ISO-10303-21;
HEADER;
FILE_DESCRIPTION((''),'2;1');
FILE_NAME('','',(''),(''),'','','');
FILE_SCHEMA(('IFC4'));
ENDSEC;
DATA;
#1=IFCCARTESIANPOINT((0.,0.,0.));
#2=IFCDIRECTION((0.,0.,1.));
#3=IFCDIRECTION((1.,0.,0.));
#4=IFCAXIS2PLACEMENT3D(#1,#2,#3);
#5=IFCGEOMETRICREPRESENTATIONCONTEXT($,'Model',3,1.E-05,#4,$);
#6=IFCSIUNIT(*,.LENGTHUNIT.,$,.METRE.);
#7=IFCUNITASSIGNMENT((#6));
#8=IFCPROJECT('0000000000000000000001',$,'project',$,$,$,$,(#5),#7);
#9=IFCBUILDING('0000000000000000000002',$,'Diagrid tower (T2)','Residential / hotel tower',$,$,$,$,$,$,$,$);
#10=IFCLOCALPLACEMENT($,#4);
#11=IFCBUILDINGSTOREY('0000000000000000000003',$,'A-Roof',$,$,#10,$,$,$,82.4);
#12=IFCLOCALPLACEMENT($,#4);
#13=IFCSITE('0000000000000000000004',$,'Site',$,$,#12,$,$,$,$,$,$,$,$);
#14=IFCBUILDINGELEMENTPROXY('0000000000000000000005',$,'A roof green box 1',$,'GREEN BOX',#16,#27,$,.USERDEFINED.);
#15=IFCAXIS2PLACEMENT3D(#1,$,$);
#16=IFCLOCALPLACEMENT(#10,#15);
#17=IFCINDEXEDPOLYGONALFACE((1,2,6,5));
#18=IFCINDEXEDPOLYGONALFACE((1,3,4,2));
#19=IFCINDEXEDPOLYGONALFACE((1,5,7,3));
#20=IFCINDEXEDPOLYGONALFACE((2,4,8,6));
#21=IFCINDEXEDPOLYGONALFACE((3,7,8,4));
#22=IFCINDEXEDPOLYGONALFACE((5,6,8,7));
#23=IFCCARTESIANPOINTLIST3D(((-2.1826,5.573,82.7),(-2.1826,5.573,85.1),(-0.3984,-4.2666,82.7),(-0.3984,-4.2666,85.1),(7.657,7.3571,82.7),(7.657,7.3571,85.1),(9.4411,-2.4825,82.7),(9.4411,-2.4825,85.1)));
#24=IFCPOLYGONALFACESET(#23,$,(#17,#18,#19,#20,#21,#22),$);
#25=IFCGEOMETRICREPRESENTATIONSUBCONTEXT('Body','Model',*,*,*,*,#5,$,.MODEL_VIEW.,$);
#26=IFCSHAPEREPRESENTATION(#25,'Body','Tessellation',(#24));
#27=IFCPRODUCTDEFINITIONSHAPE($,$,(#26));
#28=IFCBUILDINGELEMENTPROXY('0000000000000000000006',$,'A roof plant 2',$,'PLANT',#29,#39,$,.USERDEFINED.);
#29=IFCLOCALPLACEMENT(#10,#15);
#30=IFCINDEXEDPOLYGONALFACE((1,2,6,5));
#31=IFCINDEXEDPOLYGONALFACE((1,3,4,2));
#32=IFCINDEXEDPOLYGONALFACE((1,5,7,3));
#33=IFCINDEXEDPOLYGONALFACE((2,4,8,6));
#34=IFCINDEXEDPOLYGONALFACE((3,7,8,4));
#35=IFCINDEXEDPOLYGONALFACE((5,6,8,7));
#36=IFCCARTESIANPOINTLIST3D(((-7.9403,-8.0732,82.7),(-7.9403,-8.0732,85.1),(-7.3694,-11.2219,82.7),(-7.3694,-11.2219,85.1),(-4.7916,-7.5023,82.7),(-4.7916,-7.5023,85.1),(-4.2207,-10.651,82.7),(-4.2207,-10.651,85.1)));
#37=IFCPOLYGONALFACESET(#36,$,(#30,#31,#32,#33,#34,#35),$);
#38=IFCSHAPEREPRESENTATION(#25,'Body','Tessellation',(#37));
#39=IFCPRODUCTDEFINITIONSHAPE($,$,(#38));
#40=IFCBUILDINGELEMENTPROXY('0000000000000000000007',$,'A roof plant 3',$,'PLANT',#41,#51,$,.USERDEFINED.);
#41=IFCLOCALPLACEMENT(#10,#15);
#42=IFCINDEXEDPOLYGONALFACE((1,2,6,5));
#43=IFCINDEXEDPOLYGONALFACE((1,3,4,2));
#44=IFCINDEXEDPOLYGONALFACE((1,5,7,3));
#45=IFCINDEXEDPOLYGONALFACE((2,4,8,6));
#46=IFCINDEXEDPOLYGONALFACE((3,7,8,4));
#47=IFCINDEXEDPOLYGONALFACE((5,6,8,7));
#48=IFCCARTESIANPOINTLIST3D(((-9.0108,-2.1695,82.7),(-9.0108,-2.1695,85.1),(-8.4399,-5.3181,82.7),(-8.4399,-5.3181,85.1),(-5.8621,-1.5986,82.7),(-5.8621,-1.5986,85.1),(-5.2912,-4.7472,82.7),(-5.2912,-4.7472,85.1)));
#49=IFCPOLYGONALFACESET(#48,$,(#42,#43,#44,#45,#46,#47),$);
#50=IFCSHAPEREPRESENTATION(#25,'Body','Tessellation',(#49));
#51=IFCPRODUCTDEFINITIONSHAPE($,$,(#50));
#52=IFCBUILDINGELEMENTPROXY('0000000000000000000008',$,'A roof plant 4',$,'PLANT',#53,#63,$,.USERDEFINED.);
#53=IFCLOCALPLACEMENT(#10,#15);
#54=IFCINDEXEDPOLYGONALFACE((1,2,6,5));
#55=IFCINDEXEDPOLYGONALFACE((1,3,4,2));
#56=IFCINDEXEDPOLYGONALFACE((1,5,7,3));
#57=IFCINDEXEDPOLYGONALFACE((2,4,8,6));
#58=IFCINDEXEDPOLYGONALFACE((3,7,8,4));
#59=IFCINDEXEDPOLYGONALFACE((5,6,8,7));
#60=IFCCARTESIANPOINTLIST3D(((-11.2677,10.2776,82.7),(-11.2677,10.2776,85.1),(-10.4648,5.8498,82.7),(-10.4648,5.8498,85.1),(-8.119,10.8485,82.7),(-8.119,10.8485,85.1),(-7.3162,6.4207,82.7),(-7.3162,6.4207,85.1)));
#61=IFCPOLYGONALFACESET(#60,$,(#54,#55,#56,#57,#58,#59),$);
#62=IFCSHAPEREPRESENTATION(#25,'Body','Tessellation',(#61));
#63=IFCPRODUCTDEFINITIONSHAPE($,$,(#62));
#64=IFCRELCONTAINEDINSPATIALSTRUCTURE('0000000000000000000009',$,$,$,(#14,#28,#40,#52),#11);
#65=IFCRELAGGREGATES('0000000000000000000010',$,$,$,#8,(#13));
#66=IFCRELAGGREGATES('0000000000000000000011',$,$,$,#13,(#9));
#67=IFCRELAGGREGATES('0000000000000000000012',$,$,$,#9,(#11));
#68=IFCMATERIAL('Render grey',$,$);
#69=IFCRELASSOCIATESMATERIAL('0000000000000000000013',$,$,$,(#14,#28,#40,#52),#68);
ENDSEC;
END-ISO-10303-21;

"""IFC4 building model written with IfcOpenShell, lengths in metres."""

from ifc_helpers import new_model, si_unit, frame, origin_with_axes, place, context, subcontext, project, spatial, polyline, outline, extrude, material, element, save


model = new_model("IFC4")

# Units and contexts
model_context = context("Model", 3, precision=1e-05, world=origin_with_axes())
body_context = subcontext(model_context, "Body", "Model", "MODEL_VIEW")
ifc_project = project(units=[si_unit("LENGTHUNIT", "METRE")], contexts=[model_context])

# Site, building, storey
site_placement = place(None, origin_with_axes())
site = spatial("IfcSite", under=ifc_project, at=site_placement, Name="Site")
building = spatial("IfcBuilding", under=site, Name="Diagrid tower (T2)", Description="Residential / hotel tower")
storey_placement = place(None, origin_with_axes())
storey = spatial("IfcBuildingStorey", under=building, at=storey_placement, Name="A-Roof", Elevation=82.4)

# Building element proxies
ifc_material_1 = material(Name="Render grey")
proxy_1_placement = place(storey_placement, origin_with_axes())
element("IfcBuildingElementProxy", 1, at=proxy_1_placement, inside=storey, material=ifc_material_1, Name="A roof green box 1", ObjectType="GREEN BOX", PredefinedType="USERDEFINED", context=body_context, shape_type="SweptSolid", body=[
    extrude(outline(polyline([(9.4411, -2.4825), (7.657, 7.3571), (-2.1826, 5.573), (-0.3984, -4.2666), (9.4411, -2.4825)])), frame((0.0, 0.0, 82.7), z_axis=(0.0, 0.0, 1.0), x_axis=(1.0, 0.0, 0.0)), (0.0, 0.0, 1.0), 2.4),
])
proxy_2_placement = place(storey_placement, origin_with_axes())
element("IfcBuildingElementProxy", 2, at=proxy_2_placement, inside=storey, material=ifc_material_1, Name="A roof plant 2", ObjectType="PLANT", PredefinedType="USERDEFINED", context=body_context, shape_type="SweptSolid", body=[
    extrude(outline(polyline([(-4.2207, -10.651), (-4.7916, -7.5023), (-7.9403, -8.0732), (-7.3694, -11.2219), (-4.2207, -10.651)])), frame((0.0, 0.0, 82.7), z_axis=(0.0, 0.0, 1.0), x_axis=(1.0, 0.0, 0.0)), (0.0, 0.0, 1.0), 2.4),
])
proxy_3_placement = place(storey_placement, origin_with_axes())
element("IfcBuildingElementProxy", 3, at=proxy_3_placement, inside=storey, material=ifc_material_1, Name="A roof plant 3", ObjectType="PLANT", PredefinedType="USERDEFINED", context=body_context, shape_type="SweptSolid", body=[
    extrude(outline(polyline([(-5.2912, -4.7472), (-5.8621, -1.5986), (-9.0108, -2.1695), (-8.4399, -5.3181), (-5.2912, -4.7472)])), frame((0.0, 0.0, 82.7), z_axis=(0.0, 0.0, 1.0), x_axis=(1.0, 0.0, 0.0)), (0.0, 0.0, 1.0), 2.4),
])
proxy_4_placement = place(storey_placement, origin_with_axes())
element("IfcBuildingElementProxy", 4, at=proxy_4_placement, inside=storey, material=ifc_material_1, Name="A roof plant 4", ObjectType="PLANT", PredefinedType="USERDEFINED", context=body_context, shape_type="SweptSolid", body=[
    extrude(outline(polyline([(-7.3162, 6.4207), (-8.119, 10.8485), (-11.2677, 10.2776), (-10.4648, 5.8498), (-7.3162, 6.4207)])), frame((0.0, 0.0, 82.7), z_axis=(0.0, 0.0, 1.0), x_axis=(1.0, 0.0, 0.0)), (0.0, 0.0, 1.0), 2.4),
])

save(model, "model.ifc")
